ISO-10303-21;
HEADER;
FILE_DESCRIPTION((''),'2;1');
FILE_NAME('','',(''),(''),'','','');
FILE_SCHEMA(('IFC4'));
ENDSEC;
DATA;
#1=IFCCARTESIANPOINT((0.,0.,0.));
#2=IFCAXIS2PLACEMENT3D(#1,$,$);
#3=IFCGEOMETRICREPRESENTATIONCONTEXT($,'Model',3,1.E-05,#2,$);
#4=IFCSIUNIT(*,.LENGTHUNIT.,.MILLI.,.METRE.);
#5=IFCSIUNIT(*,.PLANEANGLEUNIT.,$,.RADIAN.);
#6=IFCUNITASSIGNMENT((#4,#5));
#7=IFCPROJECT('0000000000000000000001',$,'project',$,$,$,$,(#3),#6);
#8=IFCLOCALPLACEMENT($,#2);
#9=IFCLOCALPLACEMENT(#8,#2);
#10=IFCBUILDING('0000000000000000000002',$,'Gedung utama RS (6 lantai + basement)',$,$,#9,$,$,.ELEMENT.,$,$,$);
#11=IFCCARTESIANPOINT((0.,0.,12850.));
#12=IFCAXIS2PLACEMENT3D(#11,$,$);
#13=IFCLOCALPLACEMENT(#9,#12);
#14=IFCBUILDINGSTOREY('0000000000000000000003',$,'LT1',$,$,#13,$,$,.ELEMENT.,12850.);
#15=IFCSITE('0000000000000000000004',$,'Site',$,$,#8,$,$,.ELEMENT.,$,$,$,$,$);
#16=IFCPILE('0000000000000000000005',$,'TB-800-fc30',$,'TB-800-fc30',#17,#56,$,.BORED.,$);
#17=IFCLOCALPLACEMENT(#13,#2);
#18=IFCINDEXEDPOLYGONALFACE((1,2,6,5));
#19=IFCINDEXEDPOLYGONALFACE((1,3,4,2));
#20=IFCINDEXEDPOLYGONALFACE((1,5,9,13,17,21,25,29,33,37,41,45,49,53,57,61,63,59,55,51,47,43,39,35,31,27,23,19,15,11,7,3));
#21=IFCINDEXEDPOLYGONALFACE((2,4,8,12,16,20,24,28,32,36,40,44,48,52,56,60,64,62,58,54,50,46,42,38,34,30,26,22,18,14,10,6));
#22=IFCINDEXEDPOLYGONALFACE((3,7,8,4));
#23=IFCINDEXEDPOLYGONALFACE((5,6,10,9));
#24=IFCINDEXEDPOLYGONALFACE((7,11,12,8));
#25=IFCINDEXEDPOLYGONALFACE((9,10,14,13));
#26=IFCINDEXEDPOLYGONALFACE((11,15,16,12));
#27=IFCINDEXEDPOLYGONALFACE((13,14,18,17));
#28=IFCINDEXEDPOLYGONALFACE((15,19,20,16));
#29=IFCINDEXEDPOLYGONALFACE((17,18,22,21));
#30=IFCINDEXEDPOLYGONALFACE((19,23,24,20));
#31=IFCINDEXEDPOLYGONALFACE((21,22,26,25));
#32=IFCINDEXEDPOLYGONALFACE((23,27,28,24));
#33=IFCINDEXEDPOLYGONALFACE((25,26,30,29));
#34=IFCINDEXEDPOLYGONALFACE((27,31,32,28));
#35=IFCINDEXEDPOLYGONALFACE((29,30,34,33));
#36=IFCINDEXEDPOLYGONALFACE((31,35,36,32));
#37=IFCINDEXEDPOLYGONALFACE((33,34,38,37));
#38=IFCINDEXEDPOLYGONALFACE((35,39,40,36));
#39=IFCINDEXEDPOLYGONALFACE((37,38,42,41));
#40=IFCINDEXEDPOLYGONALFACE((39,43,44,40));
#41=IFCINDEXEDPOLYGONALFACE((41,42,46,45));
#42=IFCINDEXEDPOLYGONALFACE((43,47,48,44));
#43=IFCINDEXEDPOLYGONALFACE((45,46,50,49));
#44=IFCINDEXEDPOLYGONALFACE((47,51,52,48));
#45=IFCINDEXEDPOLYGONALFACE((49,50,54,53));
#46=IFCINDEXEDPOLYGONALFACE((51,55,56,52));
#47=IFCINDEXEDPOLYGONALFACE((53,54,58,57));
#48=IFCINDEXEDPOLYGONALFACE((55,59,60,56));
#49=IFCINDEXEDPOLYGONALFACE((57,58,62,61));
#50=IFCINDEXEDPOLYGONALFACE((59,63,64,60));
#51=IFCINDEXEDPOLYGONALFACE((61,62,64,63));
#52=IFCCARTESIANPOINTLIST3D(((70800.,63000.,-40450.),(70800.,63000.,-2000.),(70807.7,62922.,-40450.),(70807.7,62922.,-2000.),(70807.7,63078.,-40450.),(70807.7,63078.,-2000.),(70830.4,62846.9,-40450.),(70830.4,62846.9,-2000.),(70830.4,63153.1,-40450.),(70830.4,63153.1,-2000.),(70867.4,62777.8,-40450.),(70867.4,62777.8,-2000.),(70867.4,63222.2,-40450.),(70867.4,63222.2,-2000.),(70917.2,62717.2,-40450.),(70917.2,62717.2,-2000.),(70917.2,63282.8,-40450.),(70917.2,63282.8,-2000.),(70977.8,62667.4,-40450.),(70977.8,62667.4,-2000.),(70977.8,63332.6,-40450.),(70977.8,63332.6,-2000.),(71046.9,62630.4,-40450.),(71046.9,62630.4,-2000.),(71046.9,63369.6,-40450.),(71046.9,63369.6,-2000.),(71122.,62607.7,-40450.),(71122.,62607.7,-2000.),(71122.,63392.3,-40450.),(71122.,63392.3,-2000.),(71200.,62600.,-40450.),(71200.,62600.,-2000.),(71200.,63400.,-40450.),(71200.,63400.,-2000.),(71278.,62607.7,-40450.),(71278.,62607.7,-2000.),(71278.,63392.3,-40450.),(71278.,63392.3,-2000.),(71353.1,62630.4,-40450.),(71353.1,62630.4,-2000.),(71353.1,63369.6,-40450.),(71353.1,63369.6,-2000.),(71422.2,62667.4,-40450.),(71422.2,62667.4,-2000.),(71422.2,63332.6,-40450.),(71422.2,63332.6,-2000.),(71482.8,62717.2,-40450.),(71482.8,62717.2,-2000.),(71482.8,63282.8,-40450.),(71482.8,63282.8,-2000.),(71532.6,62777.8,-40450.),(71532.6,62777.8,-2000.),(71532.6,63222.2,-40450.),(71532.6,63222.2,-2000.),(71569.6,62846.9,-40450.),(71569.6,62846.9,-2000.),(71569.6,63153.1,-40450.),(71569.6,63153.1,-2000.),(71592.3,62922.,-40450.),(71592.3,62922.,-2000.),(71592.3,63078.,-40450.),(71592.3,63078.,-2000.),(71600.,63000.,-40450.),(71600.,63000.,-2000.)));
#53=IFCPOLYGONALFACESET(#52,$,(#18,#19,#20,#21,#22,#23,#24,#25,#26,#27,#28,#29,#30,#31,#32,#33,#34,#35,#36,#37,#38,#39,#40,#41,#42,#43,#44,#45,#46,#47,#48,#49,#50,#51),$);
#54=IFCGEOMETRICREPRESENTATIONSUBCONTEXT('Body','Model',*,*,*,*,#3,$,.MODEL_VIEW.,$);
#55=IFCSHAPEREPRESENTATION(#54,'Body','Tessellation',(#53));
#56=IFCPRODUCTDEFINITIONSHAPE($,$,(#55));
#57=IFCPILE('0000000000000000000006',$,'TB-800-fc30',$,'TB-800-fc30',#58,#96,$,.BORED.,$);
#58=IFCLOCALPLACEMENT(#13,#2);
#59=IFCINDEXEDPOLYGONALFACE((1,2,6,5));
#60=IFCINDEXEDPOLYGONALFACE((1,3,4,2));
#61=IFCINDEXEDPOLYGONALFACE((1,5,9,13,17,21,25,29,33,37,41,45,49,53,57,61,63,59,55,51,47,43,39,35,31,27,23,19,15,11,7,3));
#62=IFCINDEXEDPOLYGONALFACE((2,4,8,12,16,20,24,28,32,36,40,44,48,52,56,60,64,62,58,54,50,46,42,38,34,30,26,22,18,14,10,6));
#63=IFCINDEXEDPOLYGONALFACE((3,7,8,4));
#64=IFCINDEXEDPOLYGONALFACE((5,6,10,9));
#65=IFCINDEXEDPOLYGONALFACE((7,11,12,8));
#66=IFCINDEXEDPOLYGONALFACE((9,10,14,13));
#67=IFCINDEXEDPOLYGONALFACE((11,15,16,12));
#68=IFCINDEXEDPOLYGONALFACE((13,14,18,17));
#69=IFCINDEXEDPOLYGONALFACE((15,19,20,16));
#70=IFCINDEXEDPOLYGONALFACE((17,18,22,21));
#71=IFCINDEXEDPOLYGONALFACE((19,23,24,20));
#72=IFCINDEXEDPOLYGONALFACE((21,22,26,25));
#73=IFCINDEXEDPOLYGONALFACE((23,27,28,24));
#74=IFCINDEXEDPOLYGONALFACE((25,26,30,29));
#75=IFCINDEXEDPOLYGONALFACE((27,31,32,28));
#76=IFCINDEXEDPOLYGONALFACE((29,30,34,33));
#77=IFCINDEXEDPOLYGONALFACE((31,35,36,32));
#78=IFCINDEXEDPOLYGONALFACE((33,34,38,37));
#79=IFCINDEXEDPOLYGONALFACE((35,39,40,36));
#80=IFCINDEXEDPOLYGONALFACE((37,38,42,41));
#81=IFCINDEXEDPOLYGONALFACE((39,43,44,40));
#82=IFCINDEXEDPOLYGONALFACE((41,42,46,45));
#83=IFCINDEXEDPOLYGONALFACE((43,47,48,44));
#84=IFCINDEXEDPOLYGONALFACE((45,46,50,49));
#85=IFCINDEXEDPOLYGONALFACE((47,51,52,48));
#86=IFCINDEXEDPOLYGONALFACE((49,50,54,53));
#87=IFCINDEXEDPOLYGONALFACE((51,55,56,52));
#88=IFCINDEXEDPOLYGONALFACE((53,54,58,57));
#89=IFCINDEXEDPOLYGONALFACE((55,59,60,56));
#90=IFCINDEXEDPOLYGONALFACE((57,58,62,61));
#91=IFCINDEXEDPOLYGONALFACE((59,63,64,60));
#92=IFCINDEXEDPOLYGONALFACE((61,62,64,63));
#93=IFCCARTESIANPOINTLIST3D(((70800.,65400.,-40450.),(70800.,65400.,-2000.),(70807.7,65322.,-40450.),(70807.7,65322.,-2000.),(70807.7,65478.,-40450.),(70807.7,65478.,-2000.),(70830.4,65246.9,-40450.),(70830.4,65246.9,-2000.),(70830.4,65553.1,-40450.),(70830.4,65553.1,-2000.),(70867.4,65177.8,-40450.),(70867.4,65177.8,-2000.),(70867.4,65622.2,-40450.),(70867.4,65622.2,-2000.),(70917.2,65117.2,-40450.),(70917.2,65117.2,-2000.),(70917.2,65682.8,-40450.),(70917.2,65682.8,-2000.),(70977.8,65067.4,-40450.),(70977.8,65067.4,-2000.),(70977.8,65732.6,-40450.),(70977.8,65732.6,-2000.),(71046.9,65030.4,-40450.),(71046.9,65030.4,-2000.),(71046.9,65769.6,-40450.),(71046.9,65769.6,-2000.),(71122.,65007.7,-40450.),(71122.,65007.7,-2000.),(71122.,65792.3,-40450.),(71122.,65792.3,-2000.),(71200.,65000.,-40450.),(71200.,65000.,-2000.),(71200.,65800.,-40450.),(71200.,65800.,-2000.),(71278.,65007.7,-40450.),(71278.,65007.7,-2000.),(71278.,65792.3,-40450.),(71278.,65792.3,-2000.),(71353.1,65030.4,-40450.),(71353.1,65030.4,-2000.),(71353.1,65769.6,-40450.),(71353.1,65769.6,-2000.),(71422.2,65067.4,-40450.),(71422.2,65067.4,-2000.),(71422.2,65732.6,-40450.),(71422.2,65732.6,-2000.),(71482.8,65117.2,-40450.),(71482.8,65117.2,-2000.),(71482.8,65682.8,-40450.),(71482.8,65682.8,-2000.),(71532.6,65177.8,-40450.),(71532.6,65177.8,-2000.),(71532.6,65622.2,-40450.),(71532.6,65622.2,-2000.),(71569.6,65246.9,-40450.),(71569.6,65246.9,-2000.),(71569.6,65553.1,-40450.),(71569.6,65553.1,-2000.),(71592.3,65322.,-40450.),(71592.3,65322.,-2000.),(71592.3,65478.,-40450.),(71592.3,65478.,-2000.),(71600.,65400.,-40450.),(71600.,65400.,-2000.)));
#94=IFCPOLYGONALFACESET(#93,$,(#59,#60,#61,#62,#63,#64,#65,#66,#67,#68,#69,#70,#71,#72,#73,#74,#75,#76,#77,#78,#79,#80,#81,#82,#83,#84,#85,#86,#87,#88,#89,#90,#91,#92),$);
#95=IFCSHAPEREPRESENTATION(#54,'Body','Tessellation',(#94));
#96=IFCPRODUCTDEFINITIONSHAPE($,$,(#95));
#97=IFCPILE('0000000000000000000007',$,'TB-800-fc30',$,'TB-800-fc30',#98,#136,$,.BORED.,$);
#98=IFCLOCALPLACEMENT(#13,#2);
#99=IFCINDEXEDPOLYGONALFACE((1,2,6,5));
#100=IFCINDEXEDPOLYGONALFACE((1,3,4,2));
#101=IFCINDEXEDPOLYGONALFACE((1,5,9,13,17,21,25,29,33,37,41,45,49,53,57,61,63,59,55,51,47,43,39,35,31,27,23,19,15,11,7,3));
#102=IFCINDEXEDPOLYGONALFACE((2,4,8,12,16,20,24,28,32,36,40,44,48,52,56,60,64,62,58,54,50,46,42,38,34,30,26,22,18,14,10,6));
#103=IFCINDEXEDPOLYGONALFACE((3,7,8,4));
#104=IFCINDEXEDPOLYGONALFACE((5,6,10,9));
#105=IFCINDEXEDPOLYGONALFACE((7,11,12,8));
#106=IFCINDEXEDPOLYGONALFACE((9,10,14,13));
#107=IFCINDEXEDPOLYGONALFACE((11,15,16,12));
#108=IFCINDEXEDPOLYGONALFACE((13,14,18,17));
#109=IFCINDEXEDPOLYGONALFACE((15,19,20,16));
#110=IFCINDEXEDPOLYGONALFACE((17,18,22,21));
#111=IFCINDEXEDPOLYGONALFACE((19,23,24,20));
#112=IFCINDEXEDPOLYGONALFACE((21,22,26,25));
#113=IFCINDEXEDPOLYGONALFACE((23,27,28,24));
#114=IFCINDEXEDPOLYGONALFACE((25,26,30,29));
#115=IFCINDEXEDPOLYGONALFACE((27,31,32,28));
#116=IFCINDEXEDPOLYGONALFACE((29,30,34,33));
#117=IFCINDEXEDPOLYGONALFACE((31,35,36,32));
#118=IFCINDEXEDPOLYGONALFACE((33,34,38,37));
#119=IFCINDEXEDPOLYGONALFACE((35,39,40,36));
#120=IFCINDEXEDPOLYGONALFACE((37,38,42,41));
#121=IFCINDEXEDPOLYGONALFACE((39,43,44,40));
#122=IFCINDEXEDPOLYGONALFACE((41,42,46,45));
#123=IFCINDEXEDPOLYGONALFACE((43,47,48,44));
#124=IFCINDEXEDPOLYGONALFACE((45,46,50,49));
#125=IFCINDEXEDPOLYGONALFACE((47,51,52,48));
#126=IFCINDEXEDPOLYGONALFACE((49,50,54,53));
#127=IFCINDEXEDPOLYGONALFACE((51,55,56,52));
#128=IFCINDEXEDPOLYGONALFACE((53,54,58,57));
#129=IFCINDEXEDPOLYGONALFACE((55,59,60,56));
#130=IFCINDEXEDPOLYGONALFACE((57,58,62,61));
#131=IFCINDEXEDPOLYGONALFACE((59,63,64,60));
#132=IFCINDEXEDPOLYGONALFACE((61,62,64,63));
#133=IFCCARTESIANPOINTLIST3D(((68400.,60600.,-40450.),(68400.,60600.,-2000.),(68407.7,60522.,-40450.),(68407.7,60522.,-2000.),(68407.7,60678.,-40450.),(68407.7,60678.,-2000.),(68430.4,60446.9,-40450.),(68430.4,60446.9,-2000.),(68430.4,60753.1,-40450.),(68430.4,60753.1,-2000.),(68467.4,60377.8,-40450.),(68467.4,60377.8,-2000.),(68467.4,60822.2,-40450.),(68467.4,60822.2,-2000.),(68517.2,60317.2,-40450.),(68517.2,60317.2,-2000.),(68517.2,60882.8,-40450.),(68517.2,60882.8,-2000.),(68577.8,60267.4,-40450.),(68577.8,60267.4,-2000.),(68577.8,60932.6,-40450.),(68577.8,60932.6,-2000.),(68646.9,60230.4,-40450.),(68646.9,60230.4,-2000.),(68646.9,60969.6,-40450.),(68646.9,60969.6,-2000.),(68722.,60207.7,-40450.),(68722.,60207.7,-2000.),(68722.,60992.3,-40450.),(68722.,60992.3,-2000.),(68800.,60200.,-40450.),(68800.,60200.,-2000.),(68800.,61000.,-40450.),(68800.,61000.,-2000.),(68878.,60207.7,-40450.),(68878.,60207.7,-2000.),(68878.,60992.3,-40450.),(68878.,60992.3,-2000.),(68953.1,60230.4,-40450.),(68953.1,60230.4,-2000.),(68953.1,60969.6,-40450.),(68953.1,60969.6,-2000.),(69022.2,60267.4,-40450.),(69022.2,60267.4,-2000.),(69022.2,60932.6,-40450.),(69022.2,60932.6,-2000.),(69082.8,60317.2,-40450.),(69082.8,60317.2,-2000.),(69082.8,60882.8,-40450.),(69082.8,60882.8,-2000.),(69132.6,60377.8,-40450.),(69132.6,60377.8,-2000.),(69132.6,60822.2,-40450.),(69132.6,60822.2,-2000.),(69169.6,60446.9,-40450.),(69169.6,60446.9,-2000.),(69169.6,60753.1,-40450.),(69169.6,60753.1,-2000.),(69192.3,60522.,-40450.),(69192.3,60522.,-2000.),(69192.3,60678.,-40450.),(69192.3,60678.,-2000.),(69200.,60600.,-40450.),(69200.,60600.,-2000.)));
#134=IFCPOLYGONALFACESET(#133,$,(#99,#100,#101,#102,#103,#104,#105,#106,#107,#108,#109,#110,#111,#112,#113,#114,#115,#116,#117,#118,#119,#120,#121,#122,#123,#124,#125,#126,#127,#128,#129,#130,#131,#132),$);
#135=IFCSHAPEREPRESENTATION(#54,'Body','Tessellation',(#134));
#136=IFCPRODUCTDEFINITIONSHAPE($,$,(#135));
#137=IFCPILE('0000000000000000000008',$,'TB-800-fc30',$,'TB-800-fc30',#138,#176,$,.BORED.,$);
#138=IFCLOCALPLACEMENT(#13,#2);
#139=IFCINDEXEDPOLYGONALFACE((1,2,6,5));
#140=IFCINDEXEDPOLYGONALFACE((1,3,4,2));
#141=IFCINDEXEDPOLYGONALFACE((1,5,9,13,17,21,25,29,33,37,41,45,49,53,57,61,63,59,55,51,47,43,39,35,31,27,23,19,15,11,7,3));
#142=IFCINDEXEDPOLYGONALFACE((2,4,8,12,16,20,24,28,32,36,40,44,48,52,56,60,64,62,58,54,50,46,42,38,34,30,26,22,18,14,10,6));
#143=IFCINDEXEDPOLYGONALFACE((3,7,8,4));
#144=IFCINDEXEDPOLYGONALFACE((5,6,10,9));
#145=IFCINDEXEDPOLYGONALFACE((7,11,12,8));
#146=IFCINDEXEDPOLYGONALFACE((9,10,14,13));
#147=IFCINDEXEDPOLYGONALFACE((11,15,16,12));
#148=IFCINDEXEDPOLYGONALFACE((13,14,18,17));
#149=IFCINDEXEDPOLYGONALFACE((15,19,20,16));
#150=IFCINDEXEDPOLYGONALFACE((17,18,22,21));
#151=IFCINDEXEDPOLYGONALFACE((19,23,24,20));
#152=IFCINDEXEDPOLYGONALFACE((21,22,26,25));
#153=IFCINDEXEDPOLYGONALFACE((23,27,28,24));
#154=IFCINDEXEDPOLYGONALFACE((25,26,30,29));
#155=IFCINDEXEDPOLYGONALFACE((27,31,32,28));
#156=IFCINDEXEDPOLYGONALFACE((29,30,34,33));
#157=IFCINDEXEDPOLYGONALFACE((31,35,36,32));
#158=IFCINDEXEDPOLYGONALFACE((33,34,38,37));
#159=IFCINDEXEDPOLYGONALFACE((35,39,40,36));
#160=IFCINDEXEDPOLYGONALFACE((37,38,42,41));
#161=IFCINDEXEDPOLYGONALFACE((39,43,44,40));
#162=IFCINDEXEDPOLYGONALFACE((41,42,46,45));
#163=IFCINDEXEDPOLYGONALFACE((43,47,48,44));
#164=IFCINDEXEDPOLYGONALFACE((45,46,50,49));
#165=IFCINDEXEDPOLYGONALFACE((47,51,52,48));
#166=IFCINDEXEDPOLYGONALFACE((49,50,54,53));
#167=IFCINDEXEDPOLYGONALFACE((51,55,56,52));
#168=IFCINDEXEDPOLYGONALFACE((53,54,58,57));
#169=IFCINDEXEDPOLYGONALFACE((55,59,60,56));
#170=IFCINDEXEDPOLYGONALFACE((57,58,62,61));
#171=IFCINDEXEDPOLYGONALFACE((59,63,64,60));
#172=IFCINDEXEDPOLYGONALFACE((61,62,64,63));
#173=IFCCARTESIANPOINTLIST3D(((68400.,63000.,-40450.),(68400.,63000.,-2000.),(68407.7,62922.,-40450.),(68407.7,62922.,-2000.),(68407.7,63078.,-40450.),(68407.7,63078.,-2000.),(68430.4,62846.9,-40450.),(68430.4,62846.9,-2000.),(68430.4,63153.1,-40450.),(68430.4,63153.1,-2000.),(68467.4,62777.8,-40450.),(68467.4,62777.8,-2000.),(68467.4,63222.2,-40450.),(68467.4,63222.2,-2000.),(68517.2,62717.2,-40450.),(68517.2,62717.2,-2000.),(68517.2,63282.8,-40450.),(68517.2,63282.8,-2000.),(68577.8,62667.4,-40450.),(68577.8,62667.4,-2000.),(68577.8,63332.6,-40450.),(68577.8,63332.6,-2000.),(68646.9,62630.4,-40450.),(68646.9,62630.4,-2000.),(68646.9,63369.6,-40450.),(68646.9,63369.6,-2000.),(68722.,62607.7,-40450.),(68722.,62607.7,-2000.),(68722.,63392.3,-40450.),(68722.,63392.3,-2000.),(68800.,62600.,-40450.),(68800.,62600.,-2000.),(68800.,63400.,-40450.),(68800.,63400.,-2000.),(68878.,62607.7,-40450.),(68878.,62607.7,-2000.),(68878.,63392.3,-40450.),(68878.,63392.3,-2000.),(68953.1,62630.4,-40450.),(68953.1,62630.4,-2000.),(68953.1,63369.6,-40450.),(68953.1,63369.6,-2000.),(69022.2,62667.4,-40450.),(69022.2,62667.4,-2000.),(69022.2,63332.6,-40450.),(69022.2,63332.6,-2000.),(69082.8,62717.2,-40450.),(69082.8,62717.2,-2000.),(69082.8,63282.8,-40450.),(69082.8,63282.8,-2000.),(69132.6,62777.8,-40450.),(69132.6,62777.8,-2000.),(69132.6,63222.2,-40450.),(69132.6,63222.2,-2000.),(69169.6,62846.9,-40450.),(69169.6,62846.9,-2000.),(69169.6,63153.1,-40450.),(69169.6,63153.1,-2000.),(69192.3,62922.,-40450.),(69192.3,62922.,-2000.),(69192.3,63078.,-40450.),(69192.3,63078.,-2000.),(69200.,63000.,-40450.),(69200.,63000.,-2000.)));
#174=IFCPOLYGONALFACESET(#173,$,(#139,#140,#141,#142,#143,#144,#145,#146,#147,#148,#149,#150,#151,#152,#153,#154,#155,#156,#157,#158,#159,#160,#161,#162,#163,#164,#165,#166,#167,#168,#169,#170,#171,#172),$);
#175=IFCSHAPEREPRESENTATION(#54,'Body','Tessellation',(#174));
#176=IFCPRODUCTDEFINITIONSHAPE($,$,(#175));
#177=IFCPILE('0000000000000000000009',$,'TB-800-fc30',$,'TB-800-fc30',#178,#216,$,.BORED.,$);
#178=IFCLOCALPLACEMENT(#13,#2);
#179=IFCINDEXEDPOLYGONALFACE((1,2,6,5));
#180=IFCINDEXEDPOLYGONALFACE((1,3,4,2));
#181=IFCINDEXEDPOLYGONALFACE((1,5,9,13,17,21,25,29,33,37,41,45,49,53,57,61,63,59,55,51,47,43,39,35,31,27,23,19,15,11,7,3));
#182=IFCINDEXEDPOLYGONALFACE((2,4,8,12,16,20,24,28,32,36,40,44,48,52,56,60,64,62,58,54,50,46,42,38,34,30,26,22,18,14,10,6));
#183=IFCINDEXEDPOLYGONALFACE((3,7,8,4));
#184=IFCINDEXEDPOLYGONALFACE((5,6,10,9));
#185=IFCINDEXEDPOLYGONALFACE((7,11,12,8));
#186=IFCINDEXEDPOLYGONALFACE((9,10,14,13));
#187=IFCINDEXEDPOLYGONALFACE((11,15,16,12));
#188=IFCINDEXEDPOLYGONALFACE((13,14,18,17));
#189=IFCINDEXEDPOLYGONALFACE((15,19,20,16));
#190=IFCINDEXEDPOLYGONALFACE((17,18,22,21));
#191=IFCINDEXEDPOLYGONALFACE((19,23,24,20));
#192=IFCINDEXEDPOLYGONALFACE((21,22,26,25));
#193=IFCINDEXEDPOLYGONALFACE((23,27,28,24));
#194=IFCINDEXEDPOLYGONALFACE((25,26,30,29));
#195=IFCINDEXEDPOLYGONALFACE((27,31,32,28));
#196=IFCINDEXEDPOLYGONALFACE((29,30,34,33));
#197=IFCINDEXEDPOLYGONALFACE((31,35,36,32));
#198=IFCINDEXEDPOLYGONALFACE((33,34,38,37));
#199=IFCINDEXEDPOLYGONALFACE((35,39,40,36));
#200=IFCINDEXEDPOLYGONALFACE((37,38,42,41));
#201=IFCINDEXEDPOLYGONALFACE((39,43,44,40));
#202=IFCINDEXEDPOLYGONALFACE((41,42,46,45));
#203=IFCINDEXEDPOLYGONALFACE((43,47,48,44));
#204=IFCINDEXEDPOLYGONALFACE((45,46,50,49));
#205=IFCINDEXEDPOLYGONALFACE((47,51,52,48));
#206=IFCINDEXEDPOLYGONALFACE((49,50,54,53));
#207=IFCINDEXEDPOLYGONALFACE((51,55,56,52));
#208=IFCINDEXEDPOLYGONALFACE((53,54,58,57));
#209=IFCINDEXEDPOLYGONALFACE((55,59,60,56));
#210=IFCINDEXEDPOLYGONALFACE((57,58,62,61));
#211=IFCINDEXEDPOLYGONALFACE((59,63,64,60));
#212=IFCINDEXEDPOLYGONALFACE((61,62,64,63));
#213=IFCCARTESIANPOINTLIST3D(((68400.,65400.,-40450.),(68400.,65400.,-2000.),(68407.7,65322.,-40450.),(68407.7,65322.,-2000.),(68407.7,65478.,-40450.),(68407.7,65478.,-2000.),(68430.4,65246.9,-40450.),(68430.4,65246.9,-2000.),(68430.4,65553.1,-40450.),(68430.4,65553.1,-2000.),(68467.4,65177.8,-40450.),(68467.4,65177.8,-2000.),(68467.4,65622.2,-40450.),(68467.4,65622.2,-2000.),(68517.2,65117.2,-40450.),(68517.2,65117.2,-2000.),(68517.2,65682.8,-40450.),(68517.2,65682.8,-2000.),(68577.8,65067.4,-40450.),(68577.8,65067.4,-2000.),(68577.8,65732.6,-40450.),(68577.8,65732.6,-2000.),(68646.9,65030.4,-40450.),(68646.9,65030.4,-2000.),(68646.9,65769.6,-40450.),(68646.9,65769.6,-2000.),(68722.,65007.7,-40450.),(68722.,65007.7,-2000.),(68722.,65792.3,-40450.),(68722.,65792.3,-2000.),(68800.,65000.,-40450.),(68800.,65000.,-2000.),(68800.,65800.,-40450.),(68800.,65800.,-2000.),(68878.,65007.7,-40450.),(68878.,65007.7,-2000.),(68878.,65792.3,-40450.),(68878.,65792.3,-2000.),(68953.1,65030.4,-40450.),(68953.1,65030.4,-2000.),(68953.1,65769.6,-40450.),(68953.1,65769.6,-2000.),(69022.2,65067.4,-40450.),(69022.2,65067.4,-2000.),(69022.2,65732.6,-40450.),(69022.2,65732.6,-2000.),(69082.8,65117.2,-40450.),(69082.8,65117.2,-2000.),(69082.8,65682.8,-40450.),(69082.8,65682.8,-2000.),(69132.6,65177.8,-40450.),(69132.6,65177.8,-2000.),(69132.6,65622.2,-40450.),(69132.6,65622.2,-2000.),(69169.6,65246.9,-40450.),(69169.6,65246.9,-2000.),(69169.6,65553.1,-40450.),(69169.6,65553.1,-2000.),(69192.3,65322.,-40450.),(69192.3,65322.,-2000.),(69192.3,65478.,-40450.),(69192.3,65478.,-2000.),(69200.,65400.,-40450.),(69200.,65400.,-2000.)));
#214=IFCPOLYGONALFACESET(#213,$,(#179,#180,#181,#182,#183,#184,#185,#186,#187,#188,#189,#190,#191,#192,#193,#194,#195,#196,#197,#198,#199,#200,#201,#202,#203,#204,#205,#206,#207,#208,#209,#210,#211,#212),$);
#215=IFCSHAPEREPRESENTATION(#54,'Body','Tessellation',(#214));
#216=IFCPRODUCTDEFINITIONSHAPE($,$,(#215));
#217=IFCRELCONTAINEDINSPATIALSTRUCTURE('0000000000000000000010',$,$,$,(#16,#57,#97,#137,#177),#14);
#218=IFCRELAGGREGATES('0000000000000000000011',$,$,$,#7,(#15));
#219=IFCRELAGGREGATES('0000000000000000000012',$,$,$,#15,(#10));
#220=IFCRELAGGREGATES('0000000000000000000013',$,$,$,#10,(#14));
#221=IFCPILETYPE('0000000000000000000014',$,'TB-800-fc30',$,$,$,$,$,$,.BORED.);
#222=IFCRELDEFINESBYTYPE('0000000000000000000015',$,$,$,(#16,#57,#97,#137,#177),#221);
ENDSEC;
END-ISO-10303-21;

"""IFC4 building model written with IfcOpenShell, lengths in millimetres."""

from ifc_helpers import new_model, si_unit, frame, origin, origin_2d, place, context, subcontext, project, spatial, circle, extrude, material_profile, profile_set, profile_usage, type_object, element, save


model = new_model("IFC4")

# Units and contexts
model_context = context("Model", 3, precision=1e-05, world=origin())
body_context = subcontext(model_context, "Body", "Model", "MODEL_VIEW")
ifc_project = project(units=[si_unit("LENGTHUNIT", "METRE", prefix="MILLI"), si_unit("PLANEANGLEUNIT", "RADIAN")], contexts=[model_context])

# Site, building, storey
site_placement = place(None, origin())
site = spatial("IfcSite", under=ifc_project, at=site_placement, Name="Site", CompositionType="ELEMENT")
building_placement = place(site_placement, origin())
building = spatial("IfcBuilding", under=site, at=building_placement, Name="Gedung utama RS (6 lantai + basement)", CompositionType="ELEMENT")
storey_placement = place(building_placement, frame((0.0, 0.0, 12850.0)))
storey = spatial("IfcBuildingStorey", under=building, at=storey_placement, Name="LT1", CompositionType="ELEMENT", Elevation=12850.0)

# Piles
ifc_material_profile = material_profile(None, circle(Radius=400.0, at=origin_2d()), Name="TB-800-fc30")
ifc_profile_set = profile_set([ifc_material_profile], Name="TB-800-fc30")
ifc_profile_usage = profile_usage(ifc_profile_set, cardinal=5)
pile_type = type_object("IfcPileType", Name="TB-800-fc30", PredefinedType="BORED", material=ifc_profile_set)
for number, where, z_axis, x_axis, name in (
    (1, (71200.0, 63000.0, -40450.0), (0.0, 0.0, 1.0), (1.0, 0.0, 0.0), "TB-800-fc30"),
    (2, (71200.0, 65400.0, -40450.0), (0.0, 0.0, 1.0), (1.0, 0.0, 0.0), "TB-800-fc30"),
    (3, (68800.0, 60600.0, -40450.0), (0.0, 0.0, 1.0), (1.0, 0.0, 0.0), "TB-800-fc30"),
    (4, (68800.0, 63000.0, -40450.0), (0.0, 0.0, 1.0), (1.0, 0.0, 0.0), "TB-800-fc30"),
    (5, (68800.0, 65400.0, -40450.0), (0.0, 0.0, 1.0), (1.0, 0.0, 0.0), "TB-800-fc30"),
):
    element("IfcPile", number, at=place(storey_placement, frame(where, z_axis=z_axis, x_axis=x_axis)), inside=storey, type_object=pile_type, material=ifc_profile_usage, Name=name, ObjectType="TB-800-fc30", PredefinedType="BORED", context=body_context, shape_type="SweptSolid", body=[
        extrude(circle(Radius=400.0, at=origin_2d()), origin(), (0.0, 0.0, 1.0), 38450.0),
    ])

save(model, "model.ifc")
